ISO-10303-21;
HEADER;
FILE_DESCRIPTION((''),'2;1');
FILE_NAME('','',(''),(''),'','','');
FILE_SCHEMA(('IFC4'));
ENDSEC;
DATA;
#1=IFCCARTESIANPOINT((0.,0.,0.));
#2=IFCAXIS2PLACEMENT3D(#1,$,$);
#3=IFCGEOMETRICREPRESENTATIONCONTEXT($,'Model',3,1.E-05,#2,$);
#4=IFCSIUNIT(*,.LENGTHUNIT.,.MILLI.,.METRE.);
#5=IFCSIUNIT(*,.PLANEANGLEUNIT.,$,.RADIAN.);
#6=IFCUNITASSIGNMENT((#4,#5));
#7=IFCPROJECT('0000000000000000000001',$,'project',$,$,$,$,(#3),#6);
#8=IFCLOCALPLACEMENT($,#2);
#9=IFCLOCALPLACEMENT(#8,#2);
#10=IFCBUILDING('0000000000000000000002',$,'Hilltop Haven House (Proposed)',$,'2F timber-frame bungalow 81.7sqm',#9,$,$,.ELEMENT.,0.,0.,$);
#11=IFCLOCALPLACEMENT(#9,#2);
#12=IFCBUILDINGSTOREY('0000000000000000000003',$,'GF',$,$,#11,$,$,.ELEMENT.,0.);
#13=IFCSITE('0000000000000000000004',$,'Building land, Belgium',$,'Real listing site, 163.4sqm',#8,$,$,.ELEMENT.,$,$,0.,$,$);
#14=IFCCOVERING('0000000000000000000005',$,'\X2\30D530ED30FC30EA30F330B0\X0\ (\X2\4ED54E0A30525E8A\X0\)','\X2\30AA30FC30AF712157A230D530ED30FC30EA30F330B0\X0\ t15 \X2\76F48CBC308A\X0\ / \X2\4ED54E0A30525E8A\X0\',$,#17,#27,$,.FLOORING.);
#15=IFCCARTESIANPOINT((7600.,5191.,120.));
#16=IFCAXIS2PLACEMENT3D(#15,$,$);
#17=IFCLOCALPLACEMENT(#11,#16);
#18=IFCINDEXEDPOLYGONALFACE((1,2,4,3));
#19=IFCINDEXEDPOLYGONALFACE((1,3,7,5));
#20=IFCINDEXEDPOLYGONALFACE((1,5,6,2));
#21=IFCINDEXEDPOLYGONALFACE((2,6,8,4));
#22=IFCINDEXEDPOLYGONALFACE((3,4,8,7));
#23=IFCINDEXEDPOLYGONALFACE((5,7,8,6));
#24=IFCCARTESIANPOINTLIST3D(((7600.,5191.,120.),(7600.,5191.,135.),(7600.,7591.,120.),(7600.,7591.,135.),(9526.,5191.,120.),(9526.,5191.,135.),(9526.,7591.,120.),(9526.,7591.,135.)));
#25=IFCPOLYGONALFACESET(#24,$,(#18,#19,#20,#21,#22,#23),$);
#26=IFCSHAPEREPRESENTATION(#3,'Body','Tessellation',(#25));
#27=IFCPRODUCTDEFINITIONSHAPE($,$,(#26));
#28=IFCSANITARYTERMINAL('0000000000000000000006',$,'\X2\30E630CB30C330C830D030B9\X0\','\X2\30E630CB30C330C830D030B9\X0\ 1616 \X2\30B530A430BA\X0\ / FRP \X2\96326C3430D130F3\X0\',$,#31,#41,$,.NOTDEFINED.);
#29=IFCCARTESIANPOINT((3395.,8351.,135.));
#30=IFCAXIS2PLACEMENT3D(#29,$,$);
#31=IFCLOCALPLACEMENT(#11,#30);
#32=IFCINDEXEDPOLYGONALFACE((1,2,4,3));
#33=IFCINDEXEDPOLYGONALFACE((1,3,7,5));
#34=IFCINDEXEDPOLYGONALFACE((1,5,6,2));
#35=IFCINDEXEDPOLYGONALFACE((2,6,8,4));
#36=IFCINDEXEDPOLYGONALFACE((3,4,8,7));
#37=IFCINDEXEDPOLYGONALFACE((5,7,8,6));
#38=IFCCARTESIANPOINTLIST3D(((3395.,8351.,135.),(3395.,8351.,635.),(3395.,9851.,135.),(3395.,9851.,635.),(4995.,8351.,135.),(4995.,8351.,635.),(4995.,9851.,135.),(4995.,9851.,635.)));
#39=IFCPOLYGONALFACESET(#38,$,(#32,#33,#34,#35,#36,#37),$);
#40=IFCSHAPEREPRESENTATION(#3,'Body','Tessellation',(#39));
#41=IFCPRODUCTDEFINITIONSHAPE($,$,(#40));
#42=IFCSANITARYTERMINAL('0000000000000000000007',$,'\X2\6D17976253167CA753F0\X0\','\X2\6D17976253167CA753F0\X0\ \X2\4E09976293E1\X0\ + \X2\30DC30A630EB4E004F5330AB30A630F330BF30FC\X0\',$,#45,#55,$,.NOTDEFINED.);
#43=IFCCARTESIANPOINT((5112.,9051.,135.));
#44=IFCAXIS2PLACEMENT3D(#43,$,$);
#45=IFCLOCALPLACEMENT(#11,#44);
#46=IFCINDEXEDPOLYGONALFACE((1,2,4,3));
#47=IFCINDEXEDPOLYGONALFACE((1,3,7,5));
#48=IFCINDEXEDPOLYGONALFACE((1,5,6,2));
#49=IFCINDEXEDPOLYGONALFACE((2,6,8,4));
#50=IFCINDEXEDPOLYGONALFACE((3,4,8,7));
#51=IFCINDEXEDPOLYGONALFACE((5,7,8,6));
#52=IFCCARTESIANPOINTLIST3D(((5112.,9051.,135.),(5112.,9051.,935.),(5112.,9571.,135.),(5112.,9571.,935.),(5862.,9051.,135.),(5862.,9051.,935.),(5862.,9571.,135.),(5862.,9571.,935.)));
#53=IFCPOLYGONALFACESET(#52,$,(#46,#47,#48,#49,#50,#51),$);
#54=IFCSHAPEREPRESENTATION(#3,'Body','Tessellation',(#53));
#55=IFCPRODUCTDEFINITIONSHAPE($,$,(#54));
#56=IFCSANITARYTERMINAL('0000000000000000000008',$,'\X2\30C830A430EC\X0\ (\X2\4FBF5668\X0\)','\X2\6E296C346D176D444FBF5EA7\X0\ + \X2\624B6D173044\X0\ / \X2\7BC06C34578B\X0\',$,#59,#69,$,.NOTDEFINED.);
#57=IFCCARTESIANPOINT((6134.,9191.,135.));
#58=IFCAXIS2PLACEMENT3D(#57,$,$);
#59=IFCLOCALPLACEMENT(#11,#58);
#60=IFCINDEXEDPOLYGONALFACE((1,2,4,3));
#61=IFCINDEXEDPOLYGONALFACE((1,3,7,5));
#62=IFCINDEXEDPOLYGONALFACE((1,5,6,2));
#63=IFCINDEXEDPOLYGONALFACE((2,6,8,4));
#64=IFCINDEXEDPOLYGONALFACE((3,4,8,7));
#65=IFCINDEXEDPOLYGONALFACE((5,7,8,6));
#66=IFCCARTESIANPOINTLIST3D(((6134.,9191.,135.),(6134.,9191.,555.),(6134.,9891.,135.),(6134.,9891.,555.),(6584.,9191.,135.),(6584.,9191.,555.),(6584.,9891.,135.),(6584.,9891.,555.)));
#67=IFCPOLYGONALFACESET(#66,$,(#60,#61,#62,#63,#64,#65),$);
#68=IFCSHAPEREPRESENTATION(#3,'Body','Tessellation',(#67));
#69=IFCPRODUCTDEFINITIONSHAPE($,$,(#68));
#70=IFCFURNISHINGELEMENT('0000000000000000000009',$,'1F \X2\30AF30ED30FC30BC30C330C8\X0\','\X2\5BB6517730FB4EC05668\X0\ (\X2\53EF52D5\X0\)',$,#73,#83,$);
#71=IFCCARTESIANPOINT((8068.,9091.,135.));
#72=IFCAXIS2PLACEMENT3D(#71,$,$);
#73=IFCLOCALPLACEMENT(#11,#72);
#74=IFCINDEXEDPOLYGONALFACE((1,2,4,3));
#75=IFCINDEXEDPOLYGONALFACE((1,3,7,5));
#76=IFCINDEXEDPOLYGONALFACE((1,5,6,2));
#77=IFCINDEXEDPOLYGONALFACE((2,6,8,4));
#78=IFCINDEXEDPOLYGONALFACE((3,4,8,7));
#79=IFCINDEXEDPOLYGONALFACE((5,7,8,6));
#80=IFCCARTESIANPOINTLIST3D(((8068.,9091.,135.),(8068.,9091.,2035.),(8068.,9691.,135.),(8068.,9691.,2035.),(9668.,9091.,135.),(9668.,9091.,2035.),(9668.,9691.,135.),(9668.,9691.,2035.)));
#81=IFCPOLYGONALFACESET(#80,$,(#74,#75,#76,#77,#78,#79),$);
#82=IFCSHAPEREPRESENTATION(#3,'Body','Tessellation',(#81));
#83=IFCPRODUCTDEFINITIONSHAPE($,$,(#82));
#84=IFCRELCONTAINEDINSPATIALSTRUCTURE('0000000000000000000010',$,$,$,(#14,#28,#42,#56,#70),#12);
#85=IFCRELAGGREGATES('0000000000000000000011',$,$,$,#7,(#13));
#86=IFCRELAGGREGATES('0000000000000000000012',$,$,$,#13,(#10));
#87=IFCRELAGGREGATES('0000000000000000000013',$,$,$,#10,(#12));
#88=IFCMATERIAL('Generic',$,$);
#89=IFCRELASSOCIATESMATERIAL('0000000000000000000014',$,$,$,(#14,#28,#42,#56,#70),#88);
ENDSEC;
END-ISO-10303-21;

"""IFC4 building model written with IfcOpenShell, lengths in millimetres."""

from ifc_helpers import new_model, si_unit, frame, frame_2d, origin, place, context, project, spatial, rectangle, extrude, material, element, save


model = new_model("IFC4")

# Units and contexts
model_context = context("Model", 3, precision=1e-05, world=origin())
ifc_project = project(units=[si_unit("LENGTHUNIT", "METRE", prefix="MILLI"), si_unit("PLANEANGLEUNIT", "RADIAN")], contexts=[model_context])

# Site, building, storey
site_placement = place(None, origin())
site = spatial("IfcSite", under=ifc_project, at=site_placement, Name="Building land, Belgium", ObjectType="Real listing site, 163.4sqm", CompositionType="ELEMENT", RefElevation=0.0)
building_placement = place(site_placement, origin())
building = spatial("IfcBuilding", under=site, at=building_placement, Name="Hilltop Haven House (Proposed)", ObjectType="2F timber-frame bungalow 81.7sqm", CompositionType="ELEMENT", ElevationOfRefHeight=0.0, ElevationOfTerrain=0.0)
storey_placement = place(building_placement, origin())
storey = spatial("IfcBuildingStorey", under=building, at=storey_placement, Name="GF", CompositionType="ELEMENT", Elevation=0.0)

# Covering
ifc_material_1 = material(Name="Generic")
covering_1_placement = place(storey_placement, frame((7600.0, 5191.0, 120.0)))
element("IfcCovering", 1, at=covering_1_placement, inside=storey, material=ifc_material_1, Name="フローリング (仕上げ床)", Description="オーク無垢フローリング t15 直貼り / 仕上げ床", PredefinedType="FLOORING", context=model_context, shape_type="SweptSolid", body=[
    extrude(rectangle(XDim=1926.0, YDim=2400.0, at=frame_2d((963.0, 1200.0))), frame((7600.0, 5191.0, 120.0)), (0.0, 0.0, 1.0), 15.0),
])

# Sanitary terminals
sanitary_terminal_1_placement = place(storey_placement, frame((3395.0, 8351.0, 135.0)))
element("IfcSanitaryTerminal", 2, at=sanitary_terminal_1_placement, inside=storey, material=ifc_material_1, Name="ユニットバス", Description="ユニットバス 1616 サイズ / FRP 防水パン", PredefinedType="NOTDEFINED", context=model_context, shape_type="SweptSolid", body=[
    extrude(rectangle(XDim=1600.0, YDim=1500.0, at=frame_2d((800.0, 750.0))), frame((3395.0, 8351.0, 135.0)), (0.0, 0.0, 1.0), 500.0),
])
sanitary_terminal_2_placement = place(storey_placement, frame((5112.0, 9051.0, 135.0)))
element("IfcSanitaryTerminal", 3, at=sanitary_terminal_2_placement, inside=storey, material=ifc_material_1, Name="洗面化粧台", Description="洗面化粧台 三面鏡 + ボウル一体カウンター", PredefinedType="NOTDEFINED", context=model_context, shape_type="SweptSolid", body=[
    extrude(rectangle(XDim=750.0, YDim=520.0, at=frame_2d((375.0, 260.0))), frame((5112.0, 9051.0, 135.0)), (0.0, 0.0, 1.0), 800.0),
])
sanitary_terminal_3_placement = place(storey_placement, frame((6134.0, 9191.0, 135.0)))
element("IfcSanitaryTerminal", 4, at=sanitary_terminal_3_placement, inside=storey, material=ifc_material_1, Name="トイレ (便器)", Description="温水洗浄便座 + 手洗い / 節水型", PredefinedType="NOTDEFINED", context=model_context, shape_type="SweptSolid", body=[
    extrude(rectangle(XDim=450.0, YDim=700.0, at=frame_2d((225.0, 350.0))), frame((6134.0, 9191.0, 135.0)), (0.0, 0.0, 1.0), 420.0),
])

# Furnishing element
furnishing_placement = place(storey_placement, frame((8068.0, 9091.0, 135.0)))
element("IfcFurnishingElement", 5, at=furnishing_placement, inside=storey, material=ifc_material_1, Name="1F クローゼット", Description="家具・什器 (可動)", context=model_context, shape_type="SweptSolid", body=[
    extrude(rectangle(XDim=1600.0, YDim=600.0, at=frame_2d((800.0, 300.0))), frame((8068.0, 9091.0, 135.0)), (0.0, 0.0, 1.0), 1900.0),
])

save(model, "model.ifc")
